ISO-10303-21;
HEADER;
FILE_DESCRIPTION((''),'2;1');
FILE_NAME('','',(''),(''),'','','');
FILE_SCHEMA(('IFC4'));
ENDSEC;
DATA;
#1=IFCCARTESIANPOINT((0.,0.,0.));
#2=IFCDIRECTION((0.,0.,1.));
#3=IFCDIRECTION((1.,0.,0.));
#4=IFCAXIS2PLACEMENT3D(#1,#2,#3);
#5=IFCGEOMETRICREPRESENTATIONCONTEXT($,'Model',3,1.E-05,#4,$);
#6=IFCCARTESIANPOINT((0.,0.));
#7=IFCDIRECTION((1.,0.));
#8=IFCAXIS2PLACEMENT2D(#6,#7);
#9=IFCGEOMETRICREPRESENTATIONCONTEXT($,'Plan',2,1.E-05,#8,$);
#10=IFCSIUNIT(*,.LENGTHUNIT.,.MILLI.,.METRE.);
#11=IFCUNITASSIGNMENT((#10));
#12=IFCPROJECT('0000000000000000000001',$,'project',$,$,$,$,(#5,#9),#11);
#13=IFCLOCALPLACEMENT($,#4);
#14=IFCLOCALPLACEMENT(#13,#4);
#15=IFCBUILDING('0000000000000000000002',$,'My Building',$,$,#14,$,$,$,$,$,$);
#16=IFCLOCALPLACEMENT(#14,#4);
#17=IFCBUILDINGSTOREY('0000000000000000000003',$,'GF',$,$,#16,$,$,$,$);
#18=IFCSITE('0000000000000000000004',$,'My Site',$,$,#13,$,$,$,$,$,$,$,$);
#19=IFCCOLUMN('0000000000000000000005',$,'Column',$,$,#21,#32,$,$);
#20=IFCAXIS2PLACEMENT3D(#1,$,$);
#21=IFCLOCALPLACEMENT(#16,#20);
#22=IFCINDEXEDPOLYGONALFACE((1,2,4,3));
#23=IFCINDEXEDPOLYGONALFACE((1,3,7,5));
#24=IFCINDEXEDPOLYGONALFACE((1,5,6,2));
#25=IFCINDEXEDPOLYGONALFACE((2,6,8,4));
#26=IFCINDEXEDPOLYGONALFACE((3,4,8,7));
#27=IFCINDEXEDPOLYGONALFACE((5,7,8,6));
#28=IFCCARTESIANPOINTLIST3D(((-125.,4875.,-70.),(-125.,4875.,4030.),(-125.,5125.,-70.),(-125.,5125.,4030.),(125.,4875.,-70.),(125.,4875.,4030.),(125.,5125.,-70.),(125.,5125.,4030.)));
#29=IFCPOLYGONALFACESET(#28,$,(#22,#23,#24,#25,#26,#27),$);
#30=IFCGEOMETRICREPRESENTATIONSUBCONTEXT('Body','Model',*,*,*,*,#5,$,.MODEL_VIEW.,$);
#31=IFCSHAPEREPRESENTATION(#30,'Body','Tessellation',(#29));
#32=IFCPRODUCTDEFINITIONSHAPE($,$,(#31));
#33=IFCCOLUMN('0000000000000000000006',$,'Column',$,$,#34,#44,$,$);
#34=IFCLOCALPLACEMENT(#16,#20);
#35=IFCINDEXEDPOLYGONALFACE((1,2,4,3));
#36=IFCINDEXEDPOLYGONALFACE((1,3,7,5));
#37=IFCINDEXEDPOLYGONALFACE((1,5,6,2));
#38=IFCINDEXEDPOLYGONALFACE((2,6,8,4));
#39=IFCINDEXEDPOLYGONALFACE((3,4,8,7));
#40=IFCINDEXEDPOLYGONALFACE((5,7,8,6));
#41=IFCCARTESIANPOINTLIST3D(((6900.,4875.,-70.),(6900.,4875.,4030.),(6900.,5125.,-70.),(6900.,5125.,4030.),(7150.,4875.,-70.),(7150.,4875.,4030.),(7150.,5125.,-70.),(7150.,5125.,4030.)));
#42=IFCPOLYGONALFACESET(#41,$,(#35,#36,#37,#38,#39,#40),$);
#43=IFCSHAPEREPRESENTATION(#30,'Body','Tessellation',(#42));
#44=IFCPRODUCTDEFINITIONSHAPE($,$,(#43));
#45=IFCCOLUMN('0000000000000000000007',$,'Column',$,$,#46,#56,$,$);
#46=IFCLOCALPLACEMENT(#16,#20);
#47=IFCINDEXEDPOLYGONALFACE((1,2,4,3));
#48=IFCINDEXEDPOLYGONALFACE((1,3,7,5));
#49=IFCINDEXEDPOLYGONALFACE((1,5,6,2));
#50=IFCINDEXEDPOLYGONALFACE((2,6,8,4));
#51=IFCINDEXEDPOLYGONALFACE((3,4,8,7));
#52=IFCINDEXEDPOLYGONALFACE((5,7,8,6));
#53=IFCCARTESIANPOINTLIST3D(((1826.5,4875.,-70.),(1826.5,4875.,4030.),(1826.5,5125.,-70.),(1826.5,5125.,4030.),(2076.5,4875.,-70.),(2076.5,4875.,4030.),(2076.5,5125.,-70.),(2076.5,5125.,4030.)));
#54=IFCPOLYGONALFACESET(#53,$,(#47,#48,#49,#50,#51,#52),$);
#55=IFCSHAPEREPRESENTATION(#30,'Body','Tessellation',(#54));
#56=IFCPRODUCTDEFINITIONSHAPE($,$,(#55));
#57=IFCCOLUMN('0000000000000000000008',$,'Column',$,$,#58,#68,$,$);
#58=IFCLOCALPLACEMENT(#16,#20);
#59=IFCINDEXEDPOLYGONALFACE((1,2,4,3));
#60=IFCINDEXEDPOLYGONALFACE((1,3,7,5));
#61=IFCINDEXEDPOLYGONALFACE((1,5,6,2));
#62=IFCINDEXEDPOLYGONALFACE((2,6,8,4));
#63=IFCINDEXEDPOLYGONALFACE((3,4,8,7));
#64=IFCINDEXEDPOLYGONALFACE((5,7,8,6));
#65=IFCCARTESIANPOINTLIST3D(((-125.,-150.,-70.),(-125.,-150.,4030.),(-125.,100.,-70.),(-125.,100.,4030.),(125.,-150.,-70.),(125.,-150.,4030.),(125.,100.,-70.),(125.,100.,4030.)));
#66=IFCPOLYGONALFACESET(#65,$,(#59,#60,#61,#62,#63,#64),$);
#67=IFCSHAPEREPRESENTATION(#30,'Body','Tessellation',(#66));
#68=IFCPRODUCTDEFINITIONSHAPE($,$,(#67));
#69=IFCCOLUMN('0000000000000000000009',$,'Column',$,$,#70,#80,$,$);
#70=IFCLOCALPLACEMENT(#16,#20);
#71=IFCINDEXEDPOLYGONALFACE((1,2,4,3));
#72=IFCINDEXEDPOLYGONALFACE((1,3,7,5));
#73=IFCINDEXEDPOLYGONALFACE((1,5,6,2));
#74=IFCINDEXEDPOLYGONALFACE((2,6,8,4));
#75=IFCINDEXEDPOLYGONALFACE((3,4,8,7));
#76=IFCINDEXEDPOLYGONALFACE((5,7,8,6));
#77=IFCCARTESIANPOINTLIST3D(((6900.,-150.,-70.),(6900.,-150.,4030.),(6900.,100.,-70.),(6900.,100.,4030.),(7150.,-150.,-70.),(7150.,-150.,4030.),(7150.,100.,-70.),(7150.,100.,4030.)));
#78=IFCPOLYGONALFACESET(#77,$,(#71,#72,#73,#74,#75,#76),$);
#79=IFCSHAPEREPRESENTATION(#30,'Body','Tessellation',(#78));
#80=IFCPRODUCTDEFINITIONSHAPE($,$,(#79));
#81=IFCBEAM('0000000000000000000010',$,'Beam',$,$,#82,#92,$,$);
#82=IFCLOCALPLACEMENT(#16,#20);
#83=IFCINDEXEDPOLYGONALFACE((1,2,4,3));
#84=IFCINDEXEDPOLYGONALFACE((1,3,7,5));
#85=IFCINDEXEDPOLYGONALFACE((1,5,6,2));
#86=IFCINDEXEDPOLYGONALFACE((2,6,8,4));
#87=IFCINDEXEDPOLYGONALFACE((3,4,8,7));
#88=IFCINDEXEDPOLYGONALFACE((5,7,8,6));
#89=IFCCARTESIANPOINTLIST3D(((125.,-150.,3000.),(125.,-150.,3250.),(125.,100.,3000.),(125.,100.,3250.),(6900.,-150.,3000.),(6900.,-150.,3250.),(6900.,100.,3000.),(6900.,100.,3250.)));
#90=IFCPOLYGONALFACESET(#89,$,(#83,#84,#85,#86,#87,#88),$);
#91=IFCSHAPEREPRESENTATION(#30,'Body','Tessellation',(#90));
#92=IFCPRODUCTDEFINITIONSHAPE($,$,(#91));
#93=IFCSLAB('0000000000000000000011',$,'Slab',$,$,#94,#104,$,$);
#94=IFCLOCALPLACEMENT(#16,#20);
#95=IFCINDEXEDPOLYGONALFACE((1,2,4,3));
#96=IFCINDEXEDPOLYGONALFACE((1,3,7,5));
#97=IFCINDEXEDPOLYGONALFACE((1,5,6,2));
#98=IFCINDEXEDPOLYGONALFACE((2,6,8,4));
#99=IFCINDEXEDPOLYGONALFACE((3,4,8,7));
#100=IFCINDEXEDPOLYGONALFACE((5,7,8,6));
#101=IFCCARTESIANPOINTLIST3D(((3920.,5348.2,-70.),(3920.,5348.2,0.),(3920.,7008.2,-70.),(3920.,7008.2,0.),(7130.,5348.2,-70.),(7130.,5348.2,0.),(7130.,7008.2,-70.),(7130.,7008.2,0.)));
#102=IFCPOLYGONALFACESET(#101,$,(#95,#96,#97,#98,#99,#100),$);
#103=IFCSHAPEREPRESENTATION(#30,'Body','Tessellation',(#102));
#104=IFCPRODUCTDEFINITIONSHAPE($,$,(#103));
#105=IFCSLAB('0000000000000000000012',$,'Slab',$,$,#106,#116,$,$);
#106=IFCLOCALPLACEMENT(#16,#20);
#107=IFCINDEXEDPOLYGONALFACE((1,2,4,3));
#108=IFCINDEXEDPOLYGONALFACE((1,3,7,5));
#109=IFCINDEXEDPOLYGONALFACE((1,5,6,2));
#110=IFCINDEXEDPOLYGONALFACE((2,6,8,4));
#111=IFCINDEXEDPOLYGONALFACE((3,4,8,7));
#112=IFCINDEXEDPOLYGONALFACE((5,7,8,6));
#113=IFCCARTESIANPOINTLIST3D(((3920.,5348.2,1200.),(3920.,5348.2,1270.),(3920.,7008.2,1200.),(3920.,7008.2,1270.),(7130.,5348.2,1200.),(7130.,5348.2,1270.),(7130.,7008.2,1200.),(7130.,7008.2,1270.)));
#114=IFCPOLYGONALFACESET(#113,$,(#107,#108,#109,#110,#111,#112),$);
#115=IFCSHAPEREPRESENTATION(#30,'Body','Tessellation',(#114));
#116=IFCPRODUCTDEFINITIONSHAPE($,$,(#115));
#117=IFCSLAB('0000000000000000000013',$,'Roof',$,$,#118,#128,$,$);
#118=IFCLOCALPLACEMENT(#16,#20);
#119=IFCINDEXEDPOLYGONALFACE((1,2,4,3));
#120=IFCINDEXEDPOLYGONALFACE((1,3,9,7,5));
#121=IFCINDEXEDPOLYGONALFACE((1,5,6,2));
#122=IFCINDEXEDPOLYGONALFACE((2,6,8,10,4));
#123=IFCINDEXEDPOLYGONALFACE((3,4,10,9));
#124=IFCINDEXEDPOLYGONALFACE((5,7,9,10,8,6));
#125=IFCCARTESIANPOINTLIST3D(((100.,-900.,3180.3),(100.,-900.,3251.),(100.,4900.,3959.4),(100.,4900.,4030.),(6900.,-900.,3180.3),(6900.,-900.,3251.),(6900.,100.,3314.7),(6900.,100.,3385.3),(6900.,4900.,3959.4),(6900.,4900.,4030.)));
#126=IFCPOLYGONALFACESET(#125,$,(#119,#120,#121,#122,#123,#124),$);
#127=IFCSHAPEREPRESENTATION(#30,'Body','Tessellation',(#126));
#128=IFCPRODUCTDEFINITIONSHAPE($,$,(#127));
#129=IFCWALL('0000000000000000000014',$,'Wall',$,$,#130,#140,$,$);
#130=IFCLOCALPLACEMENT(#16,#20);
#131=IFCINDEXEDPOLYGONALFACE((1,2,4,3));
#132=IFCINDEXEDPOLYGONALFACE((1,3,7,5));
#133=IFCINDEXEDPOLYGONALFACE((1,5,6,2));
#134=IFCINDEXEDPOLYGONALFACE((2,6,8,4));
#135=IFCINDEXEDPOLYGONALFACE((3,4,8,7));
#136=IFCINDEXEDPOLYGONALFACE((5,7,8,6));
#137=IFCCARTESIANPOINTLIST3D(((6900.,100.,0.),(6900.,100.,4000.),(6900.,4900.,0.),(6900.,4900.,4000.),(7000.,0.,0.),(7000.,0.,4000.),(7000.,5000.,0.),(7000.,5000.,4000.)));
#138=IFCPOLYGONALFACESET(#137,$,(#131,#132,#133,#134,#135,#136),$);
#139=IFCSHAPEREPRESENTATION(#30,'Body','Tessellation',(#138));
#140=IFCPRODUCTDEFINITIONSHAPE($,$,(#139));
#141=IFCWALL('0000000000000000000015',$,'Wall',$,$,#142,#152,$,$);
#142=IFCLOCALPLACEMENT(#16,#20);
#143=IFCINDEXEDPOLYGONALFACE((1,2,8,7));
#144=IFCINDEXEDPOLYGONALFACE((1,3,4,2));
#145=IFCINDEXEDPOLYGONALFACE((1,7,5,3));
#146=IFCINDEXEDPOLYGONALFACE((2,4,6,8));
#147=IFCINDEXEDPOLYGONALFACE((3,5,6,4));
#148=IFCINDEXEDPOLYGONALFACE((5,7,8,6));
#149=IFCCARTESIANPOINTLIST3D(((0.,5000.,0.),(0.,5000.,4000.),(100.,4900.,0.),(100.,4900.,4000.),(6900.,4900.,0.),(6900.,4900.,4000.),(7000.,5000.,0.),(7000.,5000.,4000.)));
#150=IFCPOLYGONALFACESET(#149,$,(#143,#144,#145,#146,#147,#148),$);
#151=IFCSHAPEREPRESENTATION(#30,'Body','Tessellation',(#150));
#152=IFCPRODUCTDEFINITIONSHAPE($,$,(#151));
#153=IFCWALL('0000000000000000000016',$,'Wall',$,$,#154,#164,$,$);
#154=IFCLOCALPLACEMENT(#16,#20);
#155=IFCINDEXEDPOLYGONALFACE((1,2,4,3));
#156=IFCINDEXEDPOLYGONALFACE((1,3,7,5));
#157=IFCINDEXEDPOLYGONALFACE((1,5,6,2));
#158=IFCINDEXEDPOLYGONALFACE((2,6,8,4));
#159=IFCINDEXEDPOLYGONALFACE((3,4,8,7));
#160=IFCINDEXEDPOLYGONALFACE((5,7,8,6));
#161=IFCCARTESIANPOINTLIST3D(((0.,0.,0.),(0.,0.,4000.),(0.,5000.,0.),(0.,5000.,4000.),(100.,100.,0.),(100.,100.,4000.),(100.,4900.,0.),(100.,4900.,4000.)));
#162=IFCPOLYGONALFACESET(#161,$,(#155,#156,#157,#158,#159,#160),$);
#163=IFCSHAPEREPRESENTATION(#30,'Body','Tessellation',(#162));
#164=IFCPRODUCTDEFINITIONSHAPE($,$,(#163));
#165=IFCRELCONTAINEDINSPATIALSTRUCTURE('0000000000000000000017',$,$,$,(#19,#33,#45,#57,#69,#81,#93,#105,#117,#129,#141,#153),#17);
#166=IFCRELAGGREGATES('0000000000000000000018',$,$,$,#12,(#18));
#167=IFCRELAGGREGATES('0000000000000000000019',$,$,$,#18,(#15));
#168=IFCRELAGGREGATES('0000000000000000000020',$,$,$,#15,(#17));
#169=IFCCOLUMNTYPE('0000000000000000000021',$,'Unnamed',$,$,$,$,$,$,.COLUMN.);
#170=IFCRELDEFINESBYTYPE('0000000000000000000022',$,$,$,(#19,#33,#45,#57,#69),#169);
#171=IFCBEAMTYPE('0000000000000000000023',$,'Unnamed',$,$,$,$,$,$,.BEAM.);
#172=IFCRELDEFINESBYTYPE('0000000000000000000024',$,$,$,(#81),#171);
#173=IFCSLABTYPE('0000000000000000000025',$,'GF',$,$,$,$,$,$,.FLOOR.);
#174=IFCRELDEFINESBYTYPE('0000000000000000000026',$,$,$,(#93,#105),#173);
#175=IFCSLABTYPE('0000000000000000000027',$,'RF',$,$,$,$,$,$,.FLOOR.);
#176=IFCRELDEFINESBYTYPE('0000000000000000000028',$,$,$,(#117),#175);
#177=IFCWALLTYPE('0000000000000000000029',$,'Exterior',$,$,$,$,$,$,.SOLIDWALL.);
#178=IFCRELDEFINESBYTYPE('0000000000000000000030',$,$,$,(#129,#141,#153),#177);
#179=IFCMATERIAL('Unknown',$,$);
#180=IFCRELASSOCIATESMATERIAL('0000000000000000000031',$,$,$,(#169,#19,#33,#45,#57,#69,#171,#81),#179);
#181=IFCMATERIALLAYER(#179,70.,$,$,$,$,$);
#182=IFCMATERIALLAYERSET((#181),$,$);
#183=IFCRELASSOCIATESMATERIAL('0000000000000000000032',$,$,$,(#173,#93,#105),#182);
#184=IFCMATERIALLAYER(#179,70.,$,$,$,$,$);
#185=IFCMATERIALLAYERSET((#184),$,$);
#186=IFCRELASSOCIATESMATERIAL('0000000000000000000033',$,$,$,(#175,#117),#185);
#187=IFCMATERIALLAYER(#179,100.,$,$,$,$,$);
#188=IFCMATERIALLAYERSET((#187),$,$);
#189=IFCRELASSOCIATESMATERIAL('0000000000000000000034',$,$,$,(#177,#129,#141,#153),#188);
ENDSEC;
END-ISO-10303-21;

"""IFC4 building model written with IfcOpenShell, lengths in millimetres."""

from ifc_helpers import new_model, si_unit, frame, origin_with_axes, origin_2d_with_axis, place, context, subcontext, project, spatial, line, indexed_curve, rectangle, outline, extrude, material, layer, layer_set, layer_usage, material_profile, profile_set, profile_usage, type_object, element, save


model = new_model("IFC4")

# Units and contexts
model_context = context("Model", 3, precision=1e-05, world=origin_with_axes())
plan_context = context("Plan", 2, precision=1e-05, world=origin_2d_with_axis())
body_context_1 = subcontext(model_context, "Body", "Model", "MODEL_VIEW")
ifc_project = project(units=[si_unit("LENGTHUNIT", "METRE", prefix="MILLI")], contexts=[model_context, plan_context])

# Site, building, storey
site_placement = place(None, origin_with_axes())
site = spatial("IfcSite", under=ifc_project, at=site_placement, Name="My Site")
building_placement = place(site_placement, origin_with_axes())
building = spatial("IfcBuilding", under=site, at=building_placement, Name="My Building")
storey_placement = place(building_placement, origin_with_axes())
storey = spatial("IfcBuildingStorey", under=building, at=storey_placement, Name="GF")

# Columns
ifc_material = material(Name="Unknown")
ifc_material_profile_1 = material_profile(ifc_material, rectangle(XDim=250.0, YDim=250.0))
ifc_profile_set_1 = profile_set([ifc_material_profile_1])
ifc_profile_usage_1 = profile_usage(ifc_profile_set_1, cardinal=5)
column_type = type_object("IfcColumnType", Name="Unnamed", PredefinedType="COLUMN", material=ifc_profile_set_1)
column_1_placement = place(storey_placement, frame((0.0, 5000.0, -70.0), z_axis=(0.0, 0.0, 1.0), x_axis=(1.0, 0.0, 0.0)))
element("IfcColumn", 1, at=column_1_placement, inside=storey, type_object=column_type, material=ifc_profile_usage_1, Name="Column", context=body_context_1, shape_type="SweptSolid", body=[
    extrude(rectangle(XDim=250.0, YDim=250.0), origin_with_axes(), (0.0, 0.0, 1.0), 4100.0),
])
ifc_profile_usage_2 = profile_usage(ifc_profile_set_1, cardinal=5)
column_2_placement = place(storey_placement, frame((7025.0, 5000.0, -70.0), z_axis=(0.0, 0.0, 1.0), x_axis=(1.0, 0.0, 0.0)))
element("IfcColumn", 2, at=column_2_placement, inside=storey, type_object=column_type, material=ifc_profile_usage_2, Name="Column", context=body_context_1, shape_type="SweptSolid", body=[
    extrude(rectangle(XDim=250.0, YDim=250.0), origin_with_axes(), (0.0, 0.0, 1.0), 4100.0),
])
ifc_profile_usage_3 = profile_usage(ifc_profile_set_1, cardinal=5)
column_3_placement = place(storey_placement, frame((1951.5, 5000.0, -70.0), z_axis=(0.0, 0.0, 1.0), x_axis=(1.0, 0.0, 0.0)))
element("IfcColumn", 3, at=column_3_placement, inside=storey, type_object=column_type, material=ifc_profile_usage_3, Name="Column", context=body_context_1, shape_type="SweptSolid", body=[
    extrude(rectangle(XDim=250.0, YDim=250.0), origin_with_axes(), (0.0, 0.0, 1.0), 4100.0),
])
ifc_profile_usage_4 = profile_usage(ifc_profile_set_1, cardinal=5)
column_4_placement = place(storey_placement, frame((0.0, -25.0, -70.0), z_axis=(0.0, 0.0, 1.0), x_axis=(1.0, 0.0, 0.0)))
element("IfcColumn", 4, at=column_4_placement, inside=storey, type_object=column_type, material=ifc_profile_usage_4, Name="Column", context=body_context_1, shape_type="SweptSolid", body=[
    extrude(rectangle(XDim=250.0, YDim=250.0), origin_with_axes(), (0.0, 0.0, 1.0), 4100.0),
])
ifc_profile_usage_5 = profile_usage(ifc_profile_set_1, cardinal=5)
column_5_placement = place(storey_placement, frame((7025.0, -25.0, -70.0), z_axis=(0.0, 0.0, 1.0), x_axis=(1.0, 0.0, 0.0)))
element("IfcColumn", 5, at=column_5_placement, inside=storey, type_object=column_type, material=ifc_profile_usage_5, Name="Column", context=body_context_1, shape_type="SweptSolid", body=[
    extrude(rectangle(XDim=250.0, YDim=250.0), origin_with_axes(), (0.0, 0.0, 1.0), 4100.0),
])

# Beam
ifc_material_profile_2 = material_profile(ifc_material, rectangle(XDim=250.0, YDim=250.0))
ifc_profile_set_2 = profile_set([ifc_material_profile_2])
ifc_profile_usage_6 = profile_usage(ifc_profile_set_2, cardinal=5)
beam_type = type_object("IfcBeamType", Name="Unnamed", PredefinedType="BEAM", material=ifc_profile_set_2)
beam_placement = place(storey_placement, frame((125.0, -25.0, 3125.0), z_axis=(1.0, -0.000001, 0.000001), x_axis=(0.000001, 1.0, 0.0)))
element("IfcBeam", 6, at=beam_placement, inside=storey, type_object=beam_type, material=ifc_profile_usage_6, Name="Beam", context=body_context_1, shape_type="SweptSolid", body=[
    extrude(rectangle(XDim=250.0, YDim=250.0), origin_with_axes(), (0.0, 0.0, 1.0), 6775.0),
])

# Slabs
ifc_layer_1 = layer(ifc_material, 70.0)
ifc_layer_set_1 = layer_set([ifc_layer_1])
slab_type_1 = type_object("IfcSlabType", Name="GF", PredefinedType="FLOOR", material=ifc_layer_set_1)
ifc_layer_usage_1 = layer_usage(ifc_layer_set_1, "AXIS3", "POSITIVE", -70.0)
slab_1_placement = place(storey_placement, frame((3920.0, 7008.2, 0.0), z_axis=(0.0, 0.0, 1.0), x_axis=(1.0, 0.0, 0.0)))
element("IfcSlab", 7, at=slab_1_placement, inside=storey, type_object=slab_type_1, material=ifc_layer_usage_1, Name="Slab", context=body_context_1, shape_type="SweptSolid", body=[
    extrude(outline(indexed_curve([(0.0, 0.0), (3210.0, 0.0), (3210.0, -1660.0), (0.0, -1660.0), (0.0, 0.0)])), frame((0.0, 0.0, -70.0), z_axis=(0.0, 0.0, 1.0), x_axis=(1.0, 0.0, 0.0)), (0.0, 0.0, 1.0), 70.0),
])
ifc_layer_usage_2 = layer_usage(ifc_layer_set_1, "AXIS3", "POSITIVE", -70.0)
slab_2_placement = place(storey_placement, frame((3920.0, 7008.2, 1270.0), z_axis=(0.0, 0.0, 1.0), x_axis=(1.0, 0.0, 0.0)))
element("IfcSlab", 8, at=slab_2_placement, inside=storey, type_object=slab_type_1, material=ifc_layer_usage_2, Name="Slab", context=body_context_1, shape_type="SweptSolid", body=[
    extrude(outline(indexed_curve([(0.0, 0.0), (3210.0, 0.0), (3210.0, -1660.0), (0.0, -1660.0), (0.0, 0.0)])), frame((0.0, 0.0, -70.0), z_axis=(0.0, 0.0, 1.0), x_axis=(1.0, 0.0, 0.0)), (0.0, 0.0, 1.0), 70.0),
])
ifc_layer_2 = layer(ifc_material, 70.0)
ifc_layer_set_2 = layer_set([ifc_layer_2])
ifc_layer_usage_3 = layer_usage(ifc_layer_set_2, "AXIS3", "POSITIVE", -70.0)
slab_type_2 = type_object("IfcSlabType", Name="RF", PredefinedType="FLOOR", material=ifc_layer_set_2)
slab_3_placement = place(storey_placement, frame((100.0, 4900.0, 4030.0), z_axis=(0.0, -0.133121, 0.9911), x_axis=(1.0, 0.0, 0.0)))
element("IfcSlab", 9, at=slab_3_placement, inside=storey, type_object=slab_type_2, material=ifc_layer_usage_3, Name="Roof", context=body_context_1, shape_type="SweptSolid", body=[
    extrude(outline(indexed_curve([(0.0, 0.0), (6800.0, 0.0), (6800.0, -4843.1), (6800.0, -5852.1), (0.0, -5852.1), (0.0, 0.0)])), frame((0.0, -9.4, -70.0), z_axis=(0.0, 0.0, 1.0), x_axis=(1.0, 0.0, 0.0)), (0.0, 0.133121, 0.9911), 70.6),
])

# Shared definitions
ifc_layer_3 = layer(ifc_material, 100.0)
ifc_layer_set_3 = layer_set([ifc_layer_3])
wall_type_1 = type_object("IfcWallType", Name="Exterior", PredefinedType="SOLIDWALL", material=ifc_layer_set_3)

# Walls
ifc_layer_usage_4 = layer_usage(ifc_layer_set_3, "AXIS2", "POSITIVE", 0.0)
wall_1_placement = place(storey_placement, frame((7000.0, 0.0, 0.0), z_axis=(0.0, 0.0, 1.0), x_axis=(0.0, 1.0, 0.0)))
element("IfcWall", 10, at=wall_1_placement, inside=storey, type_object=wall_type_1, material=ifc_layer_usage_4, Name="Wall", context=body_context_1, shape_type="SweptSolid", body=[
    extrude(outline(indexed_curve([(0.0, 0.0), (100.0, 100.0), (4900.0, 100.0), (5000.0, 0.0)], segments=[line(1, 2, 3, 4, 1)])), origin_with_axes(), (0.0, 0.0, 1.0), 4000.0),
])
ifc_layer_usage_5 = layer_usage(ifc_layer_set_3, "AXIS2", "POSITIVE", 0.0)
wall_2_placement = place(storey_placement, frame((7000.0, 5000.0, 0.0), z_axis=(0.0, 0.0, 1.0), x_axis=(-1.0, 0.0, 0.0)))
element("IfcWall", 11, at=wall_2_placement, inside=storey, type_object=wall_type_1, material=ifc_layer_usage_5, Name="Wall", context=body_context_1, shape_type="SweptSolid", body=[
    extrude(outline(indexed_curve([(0.0, 0.0), (100.0, 100.0), (6900.0, 100.0), (7000.0, 0.0)], segments=[line(1, 2, 3, 4, 1)])), origin_with_axes(), (0.0, 0.0, 1.0), 4000.0),
])
ifc_layer_usage_6 = layer_usage(ifc_layer_set_3, "AXIS2", "POSITIVE", 0.0)
wall_3_placement = place(storey_placement, frame((0.0, 5000.0, 0.0), z_axis=(0.0, 0.0, 1.0), x_axis=(0.0, -1.0, 0.0)))
element("IfcWall", 12, at=wall_3_placement, inside=storey, type_object=wall_type_1, material=ifc_layer_usage_6, Name="Wall", context=body_context_1, shape_type="SweptSolid", body=[
    extrude(outline(indexed_curve([(0.0, 0.0), (100.0, 100.0), (4900.0, 100.0), (5000.0, 0.0)], segments=[line(1, 2, 3, 4, 1)])), origin_with_axes(), (0.0, 0.0, 1.0), 4000.0),
])

save(model, "model.ifc")
